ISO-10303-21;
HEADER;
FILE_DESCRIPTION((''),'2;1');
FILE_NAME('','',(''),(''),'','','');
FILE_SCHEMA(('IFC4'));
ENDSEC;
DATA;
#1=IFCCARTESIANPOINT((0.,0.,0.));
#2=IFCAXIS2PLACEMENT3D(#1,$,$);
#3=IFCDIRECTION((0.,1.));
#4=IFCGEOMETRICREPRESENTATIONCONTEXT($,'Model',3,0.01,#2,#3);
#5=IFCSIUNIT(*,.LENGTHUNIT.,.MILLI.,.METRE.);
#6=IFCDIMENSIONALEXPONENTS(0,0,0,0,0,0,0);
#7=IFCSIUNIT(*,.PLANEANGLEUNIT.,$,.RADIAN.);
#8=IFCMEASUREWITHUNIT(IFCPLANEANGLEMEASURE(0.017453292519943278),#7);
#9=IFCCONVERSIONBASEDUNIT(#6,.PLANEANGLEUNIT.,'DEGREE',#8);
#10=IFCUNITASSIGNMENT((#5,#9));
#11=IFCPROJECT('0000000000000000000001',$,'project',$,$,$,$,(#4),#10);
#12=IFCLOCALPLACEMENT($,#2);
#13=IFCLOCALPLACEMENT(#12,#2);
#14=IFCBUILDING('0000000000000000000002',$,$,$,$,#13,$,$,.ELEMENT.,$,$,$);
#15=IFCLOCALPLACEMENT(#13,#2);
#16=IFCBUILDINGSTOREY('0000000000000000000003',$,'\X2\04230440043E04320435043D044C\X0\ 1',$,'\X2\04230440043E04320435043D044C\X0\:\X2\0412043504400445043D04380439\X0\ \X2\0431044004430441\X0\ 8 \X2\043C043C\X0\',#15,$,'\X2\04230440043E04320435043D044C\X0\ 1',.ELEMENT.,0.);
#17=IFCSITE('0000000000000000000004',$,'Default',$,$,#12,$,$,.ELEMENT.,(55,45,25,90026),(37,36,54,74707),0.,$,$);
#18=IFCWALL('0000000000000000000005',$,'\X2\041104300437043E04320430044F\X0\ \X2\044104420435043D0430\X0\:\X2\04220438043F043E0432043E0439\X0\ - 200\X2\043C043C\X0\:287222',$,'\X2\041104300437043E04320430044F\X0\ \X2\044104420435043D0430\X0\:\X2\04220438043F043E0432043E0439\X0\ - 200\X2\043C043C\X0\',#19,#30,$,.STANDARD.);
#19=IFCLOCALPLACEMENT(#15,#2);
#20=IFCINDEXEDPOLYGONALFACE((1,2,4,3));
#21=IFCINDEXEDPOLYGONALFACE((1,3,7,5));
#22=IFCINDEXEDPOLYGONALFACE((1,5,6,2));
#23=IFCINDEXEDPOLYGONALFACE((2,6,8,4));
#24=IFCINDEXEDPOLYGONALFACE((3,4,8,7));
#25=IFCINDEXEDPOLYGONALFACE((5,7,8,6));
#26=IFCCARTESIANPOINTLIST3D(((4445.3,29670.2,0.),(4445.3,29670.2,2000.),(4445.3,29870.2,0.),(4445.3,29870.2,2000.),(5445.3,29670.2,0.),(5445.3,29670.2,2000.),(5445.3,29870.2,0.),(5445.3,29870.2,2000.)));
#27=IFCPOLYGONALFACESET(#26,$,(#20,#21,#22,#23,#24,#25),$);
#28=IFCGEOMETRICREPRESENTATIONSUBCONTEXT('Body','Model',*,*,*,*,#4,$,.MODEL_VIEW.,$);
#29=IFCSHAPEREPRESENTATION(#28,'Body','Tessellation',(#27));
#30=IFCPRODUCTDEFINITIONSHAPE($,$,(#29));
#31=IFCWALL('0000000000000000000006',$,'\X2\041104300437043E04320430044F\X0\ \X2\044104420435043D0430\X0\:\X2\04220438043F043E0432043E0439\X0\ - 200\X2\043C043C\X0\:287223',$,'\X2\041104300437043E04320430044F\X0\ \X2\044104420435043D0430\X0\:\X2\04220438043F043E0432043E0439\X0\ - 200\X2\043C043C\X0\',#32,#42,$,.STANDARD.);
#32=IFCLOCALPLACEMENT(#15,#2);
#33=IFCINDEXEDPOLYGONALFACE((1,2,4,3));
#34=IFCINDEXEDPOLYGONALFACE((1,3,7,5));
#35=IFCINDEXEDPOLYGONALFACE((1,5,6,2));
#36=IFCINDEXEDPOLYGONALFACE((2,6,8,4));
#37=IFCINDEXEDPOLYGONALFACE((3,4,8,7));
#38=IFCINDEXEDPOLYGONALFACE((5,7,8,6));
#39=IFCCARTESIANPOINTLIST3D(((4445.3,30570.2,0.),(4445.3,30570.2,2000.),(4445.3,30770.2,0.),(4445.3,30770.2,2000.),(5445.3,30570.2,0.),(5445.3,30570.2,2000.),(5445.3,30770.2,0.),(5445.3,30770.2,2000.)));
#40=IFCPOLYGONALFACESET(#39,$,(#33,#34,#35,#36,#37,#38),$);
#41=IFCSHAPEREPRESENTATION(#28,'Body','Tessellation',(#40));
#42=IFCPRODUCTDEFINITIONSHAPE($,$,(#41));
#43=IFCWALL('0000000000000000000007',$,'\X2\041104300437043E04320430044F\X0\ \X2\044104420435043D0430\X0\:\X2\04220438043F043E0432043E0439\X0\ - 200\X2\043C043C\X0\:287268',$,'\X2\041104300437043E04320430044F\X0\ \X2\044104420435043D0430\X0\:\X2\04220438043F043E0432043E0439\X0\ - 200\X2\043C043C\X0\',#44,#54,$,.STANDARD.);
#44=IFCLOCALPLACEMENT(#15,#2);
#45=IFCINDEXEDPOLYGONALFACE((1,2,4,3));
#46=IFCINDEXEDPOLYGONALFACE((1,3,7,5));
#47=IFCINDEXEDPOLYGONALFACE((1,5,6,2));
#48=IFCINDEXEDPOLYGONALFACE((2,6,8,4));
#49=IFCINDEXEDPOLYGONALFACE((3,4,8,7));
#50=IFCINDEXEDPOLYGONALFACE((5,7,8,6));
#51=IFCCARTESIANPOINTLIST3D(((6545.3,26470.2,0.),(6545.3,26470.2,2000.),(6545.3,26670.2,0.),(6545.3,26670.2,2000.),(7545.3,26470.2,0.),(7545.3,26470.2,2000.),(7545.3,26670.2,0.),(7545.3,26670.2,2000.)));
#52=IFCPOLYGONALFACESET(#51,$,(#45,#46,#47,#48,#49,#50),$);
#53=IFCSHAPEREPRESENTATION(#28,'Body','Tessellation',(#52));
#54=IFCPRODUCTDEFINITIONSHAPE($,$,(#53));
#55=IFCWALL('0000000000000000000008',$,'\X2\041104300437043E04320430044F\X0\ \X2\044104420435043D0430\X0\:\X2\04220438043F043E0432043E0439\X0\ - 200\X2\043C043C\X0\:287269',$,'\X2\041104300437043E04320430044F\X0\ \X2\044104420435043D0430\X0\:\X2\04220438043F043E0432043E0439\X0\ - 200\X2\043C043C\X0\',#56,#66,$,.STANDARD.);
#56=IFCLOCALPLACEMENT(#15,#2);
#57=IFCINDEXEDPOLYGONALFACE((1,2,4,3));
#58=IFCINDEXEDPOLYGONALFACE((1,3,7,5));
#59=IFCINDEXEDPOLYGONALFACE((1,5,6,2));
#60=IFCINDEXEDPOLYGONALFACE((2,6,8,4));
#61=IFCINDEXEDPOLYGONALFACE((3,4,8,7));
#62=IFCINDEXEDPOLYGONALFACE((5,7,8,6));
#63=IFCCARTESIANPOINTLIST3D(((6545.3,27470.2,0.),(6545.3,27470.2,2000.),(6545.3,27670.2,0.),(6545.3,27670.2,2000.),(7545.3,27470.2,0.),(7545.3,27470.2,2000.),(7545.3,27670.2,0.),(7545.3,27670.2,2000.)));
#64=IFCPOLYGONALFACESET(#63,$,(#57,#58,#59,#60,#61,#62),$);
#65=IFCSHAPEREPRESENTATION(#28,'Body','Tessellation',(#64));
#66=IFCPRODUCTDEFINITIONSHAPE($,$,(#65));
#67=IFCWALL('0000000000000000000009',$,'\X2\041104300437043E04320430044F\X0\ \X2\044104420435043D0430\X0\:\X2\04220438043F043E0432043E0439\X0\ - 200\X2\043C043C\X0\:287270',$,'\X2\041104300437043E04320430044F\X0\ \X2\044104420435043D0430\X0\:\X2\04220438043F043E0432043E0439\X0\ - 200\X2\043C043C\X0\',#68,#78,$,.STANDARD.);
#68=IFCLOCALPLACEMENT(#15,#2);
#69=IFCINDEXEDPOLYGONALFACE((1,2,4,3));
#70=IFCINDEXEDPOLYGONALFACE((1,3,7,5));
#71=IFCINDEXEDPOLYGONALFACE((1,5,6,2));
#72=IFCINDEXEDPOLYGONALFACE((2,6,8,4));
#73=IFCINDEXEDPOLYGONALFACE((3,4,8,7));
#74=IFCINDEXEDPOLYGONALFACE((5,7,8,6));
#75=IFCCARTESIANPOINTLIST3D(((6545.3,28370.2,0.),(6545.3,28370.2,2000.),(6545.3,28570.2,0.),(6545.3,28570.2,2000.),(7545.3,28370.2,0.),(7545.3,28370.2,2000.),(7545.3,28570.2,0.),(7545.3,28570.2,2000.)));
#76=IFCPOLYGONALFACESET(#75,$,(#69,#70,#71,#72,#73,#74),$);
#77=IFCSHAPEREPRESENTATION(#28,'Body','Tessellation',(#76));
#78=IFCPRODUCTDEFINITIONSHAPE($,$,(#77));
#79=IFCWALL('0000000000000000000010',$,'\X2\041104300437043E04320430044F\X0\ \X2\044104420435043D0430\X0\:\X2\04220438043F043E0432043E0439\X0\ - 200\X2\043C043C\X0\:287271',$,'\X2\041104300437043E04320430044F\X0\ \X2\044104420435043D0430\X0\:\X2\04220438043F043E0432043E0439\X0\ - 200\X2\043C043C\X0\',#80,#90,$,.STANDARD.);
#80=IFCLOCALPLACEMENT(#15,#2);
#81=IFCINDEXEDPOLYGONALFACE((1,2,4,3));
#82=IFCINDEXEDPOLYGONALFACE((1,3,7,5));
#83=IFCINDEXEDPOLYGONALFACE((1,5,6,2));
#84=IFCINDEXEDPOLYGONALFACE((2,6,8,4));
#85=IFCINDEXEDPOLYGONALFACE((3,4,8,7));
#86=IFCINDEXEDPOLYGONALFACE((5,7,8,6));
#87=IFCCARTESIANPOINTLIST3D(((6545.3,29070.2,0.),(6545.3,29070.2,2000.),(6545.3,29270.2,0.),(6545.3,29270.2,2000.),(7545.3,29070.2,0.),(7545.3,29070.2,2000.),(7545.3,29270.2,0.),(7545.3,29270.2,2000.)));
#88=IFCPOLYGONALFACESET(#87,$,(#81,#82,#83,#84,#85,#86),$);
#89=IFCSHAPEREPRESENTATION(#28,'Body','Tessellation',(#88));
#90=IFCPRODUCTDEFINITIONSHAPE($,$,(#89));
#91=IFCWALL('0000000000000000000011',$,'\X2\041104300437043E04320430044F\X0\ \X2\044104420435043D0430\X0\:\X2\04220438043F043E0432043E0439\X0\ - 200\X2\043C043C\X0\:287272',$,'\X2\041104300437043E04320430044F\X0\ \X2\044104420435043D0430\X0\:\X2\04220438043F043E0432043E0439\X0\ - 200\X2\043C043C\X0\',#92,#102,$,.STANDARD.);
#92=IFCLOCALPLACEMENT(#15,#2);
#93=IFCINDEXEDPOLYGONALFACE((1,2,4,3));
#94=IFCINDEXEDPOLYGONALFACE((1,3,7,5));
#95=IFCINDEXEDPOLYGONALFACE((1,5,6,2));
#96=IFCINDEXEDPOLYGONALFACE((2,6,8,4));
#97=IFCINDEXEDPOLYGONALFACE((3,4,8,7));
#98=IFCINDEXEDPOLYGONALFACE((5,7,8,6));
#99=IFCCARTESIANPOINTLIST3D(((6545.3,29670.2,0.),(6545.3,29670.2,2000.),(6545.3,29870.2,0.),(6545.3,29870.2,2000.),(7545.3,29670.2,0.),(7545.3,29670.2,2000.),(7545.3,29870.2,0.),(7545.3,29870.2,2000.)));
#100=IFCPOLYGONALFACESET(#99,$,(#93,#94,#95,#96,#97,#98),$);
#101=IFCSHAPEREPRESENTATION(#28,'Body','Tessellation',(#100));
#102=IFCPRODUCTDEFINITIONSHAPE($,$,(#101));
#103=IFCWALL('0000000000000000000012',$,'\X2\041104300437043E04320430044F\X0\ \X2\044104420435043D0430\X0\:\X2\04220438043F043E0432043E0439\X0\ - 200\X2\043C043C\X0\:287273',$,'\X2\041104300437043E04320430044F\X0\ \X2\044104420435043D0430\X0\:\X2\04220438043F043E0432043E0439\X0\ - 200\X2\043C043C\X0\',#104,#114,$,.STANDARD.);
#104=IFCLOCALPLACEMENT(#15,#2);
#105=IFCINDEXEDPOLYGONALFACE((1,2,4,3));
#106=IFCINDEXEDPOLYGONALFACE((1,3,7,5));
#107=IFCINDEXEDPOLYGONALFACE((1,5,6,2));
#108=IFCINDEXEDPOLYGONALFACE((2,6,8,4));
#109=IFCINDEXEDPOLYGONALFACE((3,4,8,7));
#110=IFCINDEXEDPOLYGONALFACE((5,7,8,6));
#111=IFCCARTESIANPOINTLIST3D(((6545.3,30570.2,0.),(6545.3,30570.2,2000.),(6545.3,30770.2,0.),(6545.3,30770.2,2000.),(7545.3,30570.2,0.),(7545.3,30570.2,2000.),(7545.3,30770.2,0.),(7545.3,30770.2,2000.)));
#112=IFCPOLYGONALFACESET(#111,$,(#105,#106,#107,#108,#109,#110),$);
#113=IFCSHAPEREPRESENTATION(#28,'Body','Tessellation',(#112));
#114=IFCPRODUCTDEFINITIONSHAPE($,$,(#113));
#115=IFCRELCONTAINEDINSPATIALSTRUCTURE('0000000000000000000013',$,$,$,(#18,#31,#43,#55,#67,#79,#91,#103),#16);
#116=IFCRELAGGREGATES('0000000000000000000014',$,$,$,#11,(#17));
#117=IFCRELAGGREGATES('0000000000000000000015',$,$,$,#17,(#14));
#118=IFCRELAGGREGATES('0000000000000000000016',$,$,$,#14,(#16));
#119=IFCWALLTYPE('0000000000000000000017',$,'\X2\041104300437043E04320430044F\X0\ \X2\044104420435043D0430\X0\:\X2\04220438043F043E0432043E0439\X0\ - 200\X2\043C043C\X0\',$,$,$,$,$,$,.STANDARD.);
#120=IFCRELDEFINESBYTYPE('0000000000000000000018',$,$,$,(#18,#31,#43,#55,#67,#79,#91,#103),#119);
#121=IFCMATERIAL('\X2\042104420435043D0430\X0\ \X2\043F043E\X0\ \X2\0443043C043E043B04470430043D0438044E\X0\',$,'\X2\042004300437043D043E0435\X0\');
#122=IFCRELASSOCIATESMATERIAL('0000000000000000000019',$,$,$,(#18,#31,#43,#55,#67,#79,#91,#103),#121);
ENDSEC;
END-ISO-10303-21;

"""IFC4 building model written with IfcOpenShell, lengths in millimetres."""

from ifc_helpers import new_model, entity, si_unit, converted_unit, direction, frame, origin, place, context, subcontext, project, spatial, indexed_curve, outline, extrude, material, type_object, element, save


model = new_model("IFC4")

# Units and contexts
model_context = context("Model", 3, precision=0.01, world=origin(), true_north=direction((0.0, 1.0)))
body_context = subcontext(model_context, "Body", "Model", "MODEL_VIEW")
ifc_project = project(units=[si_unit("LENGTHUNIT", "METRE", prefix="MILLI"), converted_unit("PLANEANGLEUNIT", "DEGREE", entity("IfcPlaneAngleMeasure", 0.017453292519943278), si_unit("PLANEANGLEUNIT", "RADIAN"), dimensions=[0, 0, 0, 0, 0, 0, 0])], contexts=[model_context])

# Site, building, storey
site_placement = place(None, origin())
site = spatial("IfcSite", under=ifc_project, at=site_placement, Name="Default", CompositionType="ELEMENT", RefLatitude=(55, 45, 25, 90026), RefLongitude=(37, 36, 54, 74707), RefElevation=0.0)
building_placement = place(site_placement, origin())
building = spatial("IfcBuilding", under=site, at=building_placement, CompositionType="ELEMENT")
storey_placement = place(building_placement, origin())
storey = spatial("IfcBuildingStorey", under=building, at=storey_placement, Name="Уровень 1", ObjectType="Уровень:Верхний брус 8 мм", LongName="Уровень 1", CompositionType="ELEMENT", Elevation=0.0)

# Walls
ifc_material = material(Name="Стена по умолчанию", Category="Разное")
wall_type = type_object("IfcWallType", Name="Базовая стена:Типовой - 200мм", PredefinedType="STANDARD")
for number, where, name in (
    (1, (4445.3, 29770.2, 0.0), "Базовая стена:Типовой - 200мм:287222"),
    (2, (4445.3, 30670.2, 0.0), "Базовая стена:Типовой - 200мм:287223"),
):
    element("IfcWall", number, at=place(storey_placement, frame(where)), inside=storey, type_object=wall_type, material=ifc_material, Name=name, ObjectType="Базовая стена:Типовой - 200мм", PredefinedType="STANDARD", context=body_context, shape_type="SweptSolid", body=[
        extrude(outline(indexed_curve([(1000.0, 100.0), (0.0, 100.0), (0.0, -100.0), (1000.0, -100.0), (1000.0, 100.0)], self_intersect=False)), origin(), (0.0, 0.0, 1.0), 2000.0),
    ])
for number, where, name in (
    (3, (6545.3, 26570.2, 0.0), "Базовая стена:Типовой - 200мм:287268"),
    (4, (6545.3, 27570.2, 0.0), "Базовая стена:Типовой - 200мм:287269"),
):
    element("IfcWall", number, at=place(storey_placement, frame(where)), inside=storey, type_object=wall_type, material=ifc_material, Name=name, ObjectType="Базовая стена:Типовой - 200мм", PredefinedType="STANDARD", context=body_context, shape_type="SweptSolid", body=[
        extrude(outline(indexed_curve([(1000.0, 100.0), (0.0, 100.0), (0.0, -100.0), (1000.0, -100.0), (1000.0, 100.0)], self_intersect=False)), origin(), (0.0, 0.0, 1.0), 2000.0),
    ])
for number, where, name in (
    (5, (6545.3, 28470.2, 0.0), "Базовая стена:Типовой - 200мм:287270"),
    (6, (6545.3, 29170.2, 0.0), "Базовая стена:Типовой - 200мм:287271"),
):
    element("IfcWall", number, at=place(storey_placement, frame(where)), inside=storey, type_object=wall_type, material=ifc_material, Name=name, ObjectType="Базовая стена:Типовой - 200мм", PredefinedType="STANDARD", context=body_context, shape_type="SweptSolid", body=[
        extrude(outline(indexed_curve([(1000.0, 100.0), (0.0, 100.0), (0.0, -100.0), (1000.0, -100.0), (1000.0, 100.0)], self_intersect=False)), origin(), (0.0, 0.0, 1.0), 2000.0),
    ])
for number, where, name in (
    (7, (6545.3, 29770.2, 0.0), "Базовая стена:Типовой - 200мм:287272"),
    (8, (6545.3, 30670.2, 0.0), "Базовая стена:Типовой - 200мм:287273"),
):
    element("IfcWall", number, at=place(storey_placement, frame(where)), inside=storey, type_object=wall_type, material=ifc_material, Name=name, ObjectType="Базовая стена:Типовой - 200мм", PredefinedType="STANDARD", context=body_context, shape_type="SweptSolid", body=[
        extrude(outline(indexed_curve([(1000.0, 100.0), (0.0, 100.0), (0.0, -100.0), (1000.0, -100.0), (1000.0, 100.0)], self_intersect=False)), origin(), (0.0, 0.0, 1.0), 2000.0),
    ])

save(model, "model.ifc")
